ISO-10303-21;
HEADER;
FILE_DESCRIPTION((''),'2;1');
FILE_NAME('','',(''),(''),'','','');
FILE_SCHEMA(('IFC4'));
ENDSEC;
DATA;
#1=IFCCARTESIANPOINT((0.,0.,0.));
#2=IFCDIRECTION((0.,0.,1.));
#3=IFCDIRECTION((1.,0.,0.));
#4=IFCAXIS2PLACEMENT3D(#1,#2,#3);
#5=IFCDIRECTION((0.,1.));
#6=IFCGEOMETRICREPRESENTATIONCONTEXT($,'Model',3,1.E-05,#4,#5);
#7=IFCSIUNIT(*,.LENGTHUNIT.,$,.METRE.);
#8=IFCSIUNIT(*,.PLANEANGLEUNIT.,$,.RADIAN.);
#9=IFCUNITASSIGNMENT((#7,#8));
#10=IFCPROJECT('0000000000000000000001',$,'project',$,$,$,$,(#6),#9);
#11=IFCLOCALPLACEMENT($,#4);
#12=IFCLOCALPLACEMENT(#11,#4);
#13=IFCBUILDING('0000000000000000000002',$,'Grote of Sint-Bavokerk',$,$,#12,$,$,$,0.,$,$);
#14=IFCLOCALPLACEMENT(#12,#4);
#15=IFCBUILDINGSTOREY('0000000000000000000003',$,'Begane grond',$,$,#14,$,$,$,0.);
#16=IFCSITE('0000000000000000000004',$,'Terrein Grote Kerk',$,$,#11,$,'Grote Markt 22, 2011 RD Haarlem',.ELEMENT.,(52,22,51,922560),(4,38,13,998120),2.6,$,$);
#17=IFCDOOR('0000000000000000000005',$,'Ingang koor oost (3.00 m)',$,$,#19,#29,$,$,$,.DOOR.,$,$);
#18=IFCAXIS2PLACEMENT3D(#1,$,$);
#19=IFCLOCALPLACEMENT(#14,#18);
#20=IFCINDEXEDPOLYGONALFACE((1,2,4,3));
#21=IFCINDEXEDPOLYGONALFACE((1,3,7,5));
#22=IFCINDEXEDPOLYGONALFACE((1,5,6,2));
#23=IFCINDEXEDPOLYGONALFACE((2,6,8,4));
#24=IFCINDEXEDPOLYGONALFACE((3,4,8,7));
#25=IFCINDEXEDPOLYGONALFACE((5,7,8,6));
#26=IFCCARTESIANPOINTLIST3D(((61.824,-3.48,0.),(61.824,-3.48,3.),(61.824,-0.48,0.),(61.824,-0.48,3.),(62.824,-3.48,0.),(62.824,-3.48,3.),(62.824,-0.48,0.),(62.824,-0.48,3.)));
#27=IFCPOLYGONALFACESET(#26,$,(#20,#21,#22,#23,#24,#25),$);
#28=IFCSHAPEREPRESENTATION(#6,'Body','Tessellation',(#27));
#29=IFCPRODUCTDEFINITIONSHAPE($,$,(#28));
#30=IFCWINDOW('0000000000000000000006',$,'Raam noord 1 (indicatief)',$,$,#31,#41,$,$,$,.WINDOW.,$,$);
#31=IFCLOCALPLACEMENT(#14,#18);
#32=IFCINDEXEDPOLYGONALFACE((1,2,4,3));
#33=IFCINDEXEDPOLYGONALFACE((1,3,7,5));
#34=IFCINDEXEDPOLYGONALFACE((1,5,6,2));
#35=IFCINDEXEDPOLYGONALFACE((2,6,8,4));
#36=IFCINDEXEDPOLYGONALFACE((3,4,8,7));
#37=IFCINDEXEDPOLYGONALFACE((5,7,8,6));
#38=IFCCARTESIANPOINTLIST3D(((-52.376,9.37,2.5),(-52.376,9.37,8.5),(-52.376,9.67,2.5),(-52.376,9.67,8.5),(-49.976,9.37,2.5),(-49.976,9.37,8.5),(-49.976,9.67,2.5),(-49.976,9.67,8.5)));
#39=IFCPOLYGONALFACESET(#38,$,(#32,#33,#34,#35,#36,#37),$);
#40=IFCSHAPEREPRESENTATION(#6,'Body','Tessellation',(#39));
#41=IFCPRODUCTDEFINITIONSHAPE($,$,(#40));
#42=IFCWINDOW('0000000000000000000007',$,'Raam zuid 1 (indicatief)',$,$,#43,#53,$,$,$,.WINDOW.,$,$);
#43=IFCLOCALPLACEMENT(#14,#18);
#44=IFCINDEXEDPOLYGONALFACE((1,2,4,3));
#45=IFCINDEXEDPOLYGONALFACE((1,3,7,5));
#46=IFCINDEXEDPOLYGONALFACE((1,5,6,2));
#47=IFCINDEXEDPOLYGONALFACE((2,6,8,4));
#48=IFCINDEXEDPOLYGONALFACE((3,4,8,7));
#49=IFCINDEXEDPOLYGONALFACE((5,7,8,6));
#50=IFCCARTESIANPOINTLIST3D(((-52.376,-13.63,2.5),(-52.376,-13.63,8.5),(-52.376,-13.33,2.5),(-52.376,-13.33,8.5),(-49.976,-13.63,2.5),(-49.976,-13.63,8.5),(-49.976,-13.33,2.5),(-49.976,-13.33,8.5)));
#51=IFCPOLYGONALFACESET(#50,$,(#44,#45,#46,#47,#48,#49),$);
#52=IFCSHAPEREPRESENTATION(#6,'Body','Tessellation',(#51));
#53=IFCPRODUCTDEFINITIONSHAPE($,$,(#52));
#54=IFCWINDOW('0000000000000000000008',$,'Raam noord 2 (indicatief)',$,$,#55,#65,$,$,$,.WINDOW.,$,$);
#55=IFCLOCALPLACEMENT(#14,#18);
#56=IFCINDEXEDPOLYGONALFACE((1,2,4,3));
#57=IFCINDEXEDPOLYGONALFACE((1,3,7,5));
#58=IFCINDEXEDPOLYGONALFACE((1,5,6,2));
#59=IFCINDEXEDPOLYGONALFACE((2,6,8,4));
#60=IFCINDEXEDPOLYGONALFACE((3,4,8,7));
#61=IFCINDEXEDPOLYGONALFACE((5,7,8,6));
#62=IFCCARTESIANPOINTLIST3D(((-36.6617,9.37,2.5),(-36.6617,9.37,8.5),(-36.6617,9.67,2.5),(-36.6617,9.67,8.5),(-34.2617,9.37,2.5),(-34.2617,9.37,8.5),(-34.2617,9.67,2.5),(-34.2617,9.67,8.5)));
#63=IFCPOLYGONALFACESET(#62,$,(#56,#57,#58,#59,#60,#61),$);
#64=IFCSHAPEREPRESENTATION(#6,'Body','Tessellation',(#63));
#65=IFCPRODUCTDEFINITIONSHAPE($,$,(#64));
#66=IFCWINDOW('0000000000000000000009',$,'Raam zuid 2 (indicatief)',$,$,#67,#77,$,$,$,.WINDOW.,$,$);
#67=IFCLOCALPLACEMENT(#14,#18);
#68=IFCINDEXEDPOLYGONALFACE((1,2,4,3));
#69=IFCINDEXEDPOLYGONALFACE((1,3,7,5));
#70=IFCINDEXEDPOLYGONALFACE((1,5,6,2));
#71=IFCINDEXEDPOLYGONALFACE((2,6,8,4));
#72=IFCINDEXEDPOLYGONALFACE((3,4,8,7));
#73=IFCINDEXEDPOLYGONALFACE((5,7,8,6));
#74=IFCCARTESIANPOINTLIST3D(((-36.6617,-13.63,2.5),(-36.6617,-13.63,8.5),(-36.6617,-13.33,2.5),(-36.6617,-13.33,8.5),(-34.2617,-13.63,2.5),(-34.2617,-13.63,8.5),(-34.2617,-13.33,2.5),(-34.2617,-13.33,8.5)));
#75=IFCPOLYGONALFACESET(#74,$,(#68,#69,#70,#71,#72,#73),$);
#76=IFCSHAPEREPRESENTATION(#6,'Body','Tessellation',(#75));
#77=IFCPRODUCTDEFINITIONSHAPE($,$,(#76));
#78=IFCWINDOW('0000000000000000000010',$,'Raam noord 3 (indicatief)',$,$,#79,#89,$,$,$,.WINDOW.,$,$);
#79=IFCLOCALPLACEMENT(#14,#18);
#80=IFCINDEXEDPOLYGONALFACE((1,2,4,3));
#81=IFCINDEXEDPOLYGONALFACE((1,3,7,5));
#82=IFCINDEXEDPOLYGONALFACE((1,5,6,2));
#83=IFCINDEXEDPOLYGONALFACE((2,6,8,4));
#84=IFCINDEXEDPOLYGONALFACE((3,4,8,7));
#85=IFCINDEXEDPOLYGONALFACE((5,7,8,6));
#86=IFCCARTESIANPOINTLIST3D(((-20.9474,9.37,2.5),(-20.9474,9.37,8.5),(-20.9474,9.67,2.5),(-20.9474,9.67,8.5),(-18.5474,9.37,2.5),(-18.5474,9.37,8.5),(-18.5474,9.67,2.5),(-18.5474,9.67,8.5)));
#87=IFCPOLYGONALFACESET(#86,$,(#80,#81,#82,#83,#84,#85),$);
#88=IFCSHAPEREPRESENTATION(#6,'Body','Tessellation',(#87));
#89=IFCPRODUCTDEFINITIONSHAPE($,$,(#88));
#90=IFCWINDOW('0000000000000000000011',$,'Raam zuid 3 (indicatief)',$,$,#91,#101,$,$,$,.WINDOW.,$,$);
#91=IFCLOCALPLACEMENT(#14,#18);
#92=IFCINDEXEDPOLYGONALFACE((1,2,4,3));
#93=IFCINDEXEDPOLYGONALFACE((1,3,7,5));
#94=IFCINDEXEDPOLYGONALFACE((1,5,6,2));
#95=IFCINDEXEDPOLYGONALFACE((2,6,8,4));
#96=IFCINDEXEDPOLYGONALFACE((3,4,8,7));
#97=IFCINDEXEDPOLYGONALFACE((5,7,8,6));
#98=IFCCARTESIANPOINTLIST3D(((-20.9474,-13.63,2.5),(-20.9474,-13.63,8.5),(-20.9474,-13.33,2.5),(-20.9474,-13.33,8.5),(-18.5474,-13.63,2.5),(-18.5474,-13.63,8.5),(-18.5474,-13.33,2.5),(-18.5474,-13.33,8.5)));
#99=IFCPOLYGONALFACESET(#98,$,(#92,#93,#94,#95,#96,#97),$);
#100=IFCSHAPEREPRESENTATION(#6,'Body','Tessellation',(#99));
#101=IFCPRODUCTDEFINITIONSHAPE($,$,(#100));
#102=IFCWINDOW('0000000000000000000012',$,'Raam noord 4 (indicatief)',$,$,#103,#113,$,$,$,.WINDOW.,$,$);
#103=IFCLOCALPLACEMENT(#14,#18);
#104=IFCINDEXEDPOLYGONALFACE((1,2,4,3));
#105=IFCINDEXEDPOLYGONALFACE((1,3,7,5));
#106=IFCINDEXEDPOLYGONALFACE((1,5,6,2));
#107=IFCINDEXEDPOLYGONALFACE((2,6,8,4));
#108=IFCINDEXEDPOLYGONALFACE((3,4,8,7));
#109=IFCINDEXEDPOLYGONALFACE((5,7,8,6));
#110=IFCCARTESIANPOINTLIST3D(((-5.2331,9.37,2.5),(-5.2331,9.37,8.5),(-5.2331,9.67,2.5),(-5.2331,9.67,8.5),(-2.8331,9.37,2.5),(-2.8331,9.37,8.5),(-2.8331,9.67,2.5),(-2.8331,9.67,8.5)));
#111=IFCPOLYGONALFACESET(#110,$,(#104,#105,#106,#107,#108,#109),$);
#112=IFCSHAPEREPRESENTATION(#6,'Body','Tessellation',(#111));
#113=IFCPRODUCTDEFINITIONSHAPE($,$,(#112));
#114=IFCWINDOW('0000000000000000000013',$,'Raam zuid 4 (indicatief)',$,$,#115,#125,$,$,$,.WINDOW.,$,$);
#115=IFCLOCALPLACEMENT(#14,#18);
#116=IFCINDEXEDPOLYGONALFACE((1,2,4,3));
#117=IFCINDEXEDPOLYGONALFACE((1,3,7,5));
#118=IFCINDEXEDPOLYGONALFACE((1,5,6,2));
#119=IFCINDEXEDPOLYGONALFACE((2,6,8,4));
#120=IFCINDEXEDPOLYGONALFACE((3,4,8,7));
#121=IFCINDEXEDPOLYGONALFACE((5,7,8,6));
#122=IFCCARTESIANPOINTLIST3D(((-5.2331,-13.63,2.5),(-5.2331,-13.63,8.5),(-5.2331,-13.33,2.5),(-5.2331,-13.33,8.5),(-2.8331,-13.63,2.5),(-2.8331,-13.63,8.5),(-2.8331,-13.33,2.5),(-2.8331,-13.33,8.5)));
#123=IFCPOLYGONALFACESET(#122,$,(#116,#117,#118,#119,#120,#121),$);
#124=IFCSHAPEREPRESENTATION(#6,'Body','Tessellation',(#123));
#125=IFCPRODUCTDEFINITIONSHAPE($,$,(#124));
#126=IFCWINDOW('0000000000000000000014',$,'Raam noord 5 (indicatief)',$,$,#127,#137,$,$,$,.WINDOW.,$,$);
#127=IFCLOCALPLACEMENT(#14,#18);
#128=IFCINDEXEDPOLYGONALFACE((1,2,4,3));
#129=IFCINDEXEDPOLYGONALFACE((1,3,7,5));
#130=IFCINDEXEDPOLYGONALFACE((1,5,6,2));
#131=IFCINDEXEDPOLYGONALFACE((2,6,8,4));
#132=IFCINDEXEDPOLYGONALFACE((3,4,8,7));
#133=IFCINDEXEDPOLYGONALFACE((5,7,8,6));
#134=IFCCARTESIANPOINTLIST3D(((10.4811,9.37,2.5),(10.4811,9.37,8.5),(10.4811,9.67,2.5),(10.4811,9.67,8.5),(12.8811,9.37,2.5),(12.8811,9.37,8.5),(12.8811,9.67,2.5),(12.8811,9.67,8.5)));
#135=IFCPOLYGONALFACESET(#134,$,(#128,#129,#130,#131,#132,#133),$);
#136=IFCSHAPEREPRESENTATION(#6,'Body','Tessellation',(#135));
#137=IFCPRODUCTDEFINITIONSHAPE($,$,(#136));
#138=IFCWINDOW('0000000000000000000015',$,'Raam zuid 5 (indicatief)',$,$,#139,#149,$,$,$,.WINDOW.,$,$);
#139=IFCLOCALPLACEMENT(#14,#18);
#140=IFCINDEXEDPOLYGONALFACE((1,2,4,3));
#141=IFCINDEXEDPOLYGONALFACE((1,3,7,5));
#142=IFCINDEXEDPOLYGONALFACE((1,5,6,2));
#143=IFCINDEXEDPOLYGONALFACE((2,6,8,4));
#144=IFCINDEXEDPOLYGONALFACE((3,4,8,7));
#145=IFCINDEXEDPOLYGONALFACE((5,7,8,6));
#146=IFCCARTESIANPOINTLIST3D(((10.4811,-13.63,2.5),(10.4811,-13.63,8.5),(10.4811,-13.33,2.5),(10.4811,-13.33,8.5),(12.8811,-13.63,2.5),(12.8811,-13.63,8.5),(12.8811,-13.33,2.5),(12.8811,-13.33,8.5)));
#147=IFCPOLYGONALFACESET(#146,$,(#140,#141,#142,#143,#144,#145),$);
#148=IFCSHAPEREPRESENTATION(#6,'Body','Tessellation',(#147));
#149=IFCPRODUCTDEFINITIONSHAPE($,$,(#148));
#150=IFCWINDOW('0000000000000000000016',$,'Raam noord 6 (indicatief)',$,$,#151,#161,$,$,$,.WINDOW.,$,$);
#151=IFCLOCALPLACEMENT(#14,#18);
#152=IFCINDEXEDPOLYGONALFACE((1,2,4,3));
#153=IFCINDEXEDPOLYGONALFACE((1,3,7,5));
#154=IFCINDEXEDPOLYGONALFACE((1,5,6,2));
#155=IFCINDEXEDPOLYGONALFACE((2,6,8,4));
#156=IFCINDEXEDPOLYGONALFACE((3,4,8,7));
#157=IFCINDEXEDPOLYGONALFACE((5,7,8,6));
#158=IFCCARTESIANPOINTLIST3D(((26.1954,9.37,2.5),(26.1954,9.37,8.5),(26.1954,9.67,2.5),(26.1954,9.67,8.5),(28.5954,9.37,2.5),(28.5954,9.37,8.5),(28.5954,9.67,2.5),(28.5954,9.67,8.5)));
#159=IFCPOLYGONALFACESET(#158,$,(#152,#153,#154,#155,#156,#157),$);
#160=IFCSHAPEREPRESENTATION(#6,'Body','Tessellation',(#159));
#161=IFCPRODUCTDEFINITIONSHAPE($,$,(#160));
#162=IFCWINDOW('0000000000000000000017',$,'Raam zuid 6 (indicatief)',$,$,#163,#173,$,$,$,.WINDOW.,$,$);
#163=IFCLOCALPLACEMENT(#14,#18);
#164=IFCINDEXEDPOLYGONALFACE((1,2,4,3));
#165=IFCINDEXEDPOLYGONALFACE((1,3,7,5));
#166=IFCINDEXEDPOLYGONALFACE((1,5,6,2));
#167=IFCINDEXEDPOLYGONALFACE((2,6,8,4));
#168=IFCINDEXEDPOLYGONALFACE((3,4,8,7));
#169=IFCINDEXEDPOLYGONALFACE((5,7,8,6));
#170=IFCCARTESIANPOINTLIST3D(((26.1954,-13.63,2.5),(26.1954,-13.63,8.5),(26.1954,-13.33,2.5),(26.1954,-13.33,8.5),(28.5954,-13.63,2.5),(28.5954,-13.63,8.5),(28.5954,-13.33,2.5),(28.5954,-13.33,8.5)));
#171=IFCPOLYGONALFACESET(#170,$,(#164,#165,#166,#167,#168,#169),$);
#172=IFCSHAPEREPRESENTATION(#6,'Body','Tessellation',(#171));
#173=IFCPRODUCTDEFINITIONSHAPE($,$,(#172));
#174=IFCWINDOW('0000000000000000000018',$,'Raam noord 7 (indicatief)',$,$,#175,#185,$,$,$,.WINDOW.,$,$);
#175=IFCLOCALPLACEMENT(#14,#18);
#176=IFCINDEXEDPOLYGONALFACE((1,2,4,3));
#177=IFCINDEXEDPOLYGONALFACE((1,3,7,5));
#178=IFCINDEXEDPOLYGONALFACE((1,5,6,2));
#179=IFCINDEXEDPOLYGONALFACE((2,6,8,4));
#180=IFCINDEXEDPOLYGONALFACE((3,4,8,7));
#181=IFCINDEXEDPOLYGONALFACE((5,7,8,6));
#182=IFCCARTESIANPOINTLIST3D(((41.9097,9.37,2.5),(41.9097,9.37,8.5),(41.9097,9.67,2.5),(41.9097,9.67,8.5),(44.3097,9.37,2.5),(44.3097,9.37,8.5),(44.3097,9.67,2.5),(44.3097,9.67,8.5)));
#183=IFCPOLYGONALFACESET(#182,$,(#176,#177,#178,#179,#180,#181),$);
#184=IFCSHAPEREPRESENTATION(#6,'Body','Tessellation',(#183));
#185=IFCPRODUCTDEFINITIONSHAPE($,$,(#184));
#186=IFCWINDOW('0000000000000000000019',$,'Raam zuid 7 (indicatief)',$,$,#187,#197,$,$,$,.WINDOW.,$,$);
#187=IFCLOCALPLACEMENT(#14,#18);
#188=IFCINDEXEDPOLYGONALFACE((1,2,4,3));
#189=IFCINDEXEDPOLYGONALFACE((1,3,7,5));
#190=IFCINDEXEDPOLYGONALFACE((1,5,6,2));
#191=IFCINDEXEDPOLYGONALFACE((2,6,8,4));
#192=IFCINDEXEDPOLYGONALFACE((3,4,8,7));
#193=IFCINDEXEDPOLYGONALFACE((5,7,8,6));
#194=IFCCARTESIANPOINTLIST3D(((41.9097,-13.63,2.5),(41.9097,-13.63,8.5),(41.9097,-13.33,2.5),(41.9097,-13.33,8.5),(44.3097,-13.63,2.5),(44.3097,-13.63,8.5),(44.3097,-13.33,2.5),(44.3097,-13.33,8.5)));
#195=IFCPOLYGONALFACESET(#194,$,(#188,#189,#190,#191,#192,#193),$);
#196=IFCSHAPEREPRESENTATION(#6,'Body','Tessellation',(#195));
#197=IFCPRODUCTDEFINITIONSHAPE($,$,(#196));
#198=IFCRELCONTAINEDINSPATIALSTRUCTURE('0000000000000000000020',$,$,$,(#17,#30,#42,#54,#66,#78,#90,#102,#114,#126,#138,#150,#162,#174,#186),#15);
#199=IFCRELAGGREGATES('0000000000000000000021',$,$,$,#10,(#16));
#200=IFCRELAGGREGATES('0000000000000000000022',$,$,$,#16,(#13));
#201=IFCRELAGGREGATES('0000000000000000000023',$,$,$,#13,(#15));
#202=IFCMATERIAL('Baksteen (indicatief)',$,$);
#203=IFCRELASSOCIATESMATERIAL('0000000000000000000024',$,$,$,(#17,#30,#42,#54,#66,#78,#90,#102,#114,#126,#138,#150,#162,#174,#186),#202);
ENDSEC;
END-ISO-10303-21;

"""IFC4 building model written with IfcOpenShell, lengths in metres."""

from ifc_helpers import new_model, si_unit, direction, frame, origin_with_axes, place, context, project, spatial, indexed_curve, outline, extrude, material, element, save


model = new_model("IFC4")

# Units and contexts
model_context = context("Model", 3, precision=1e-05, world=origin_with_axes(), true_north=direction((0.0, 1.0)))
ifc_project = project(units=[si_unit("LENGTHUNIT", "METRE"), si_unit("PLANEANGLEUNIT", "RADIAN")], contexts=[model_context])

# Site, building, storey
site_placement = place(None, origin_with_axes())
site = spatial("IfcSite", under=ifc_project, at=site_placement, Name="Terrein Grote Kerk", LongName="Grote Markt 22, 2011 RD Haarlem", CompositionType="ELEMENT", RefLatitude=(52, 22, 51, 922560), RefLongitude=(4, 38, 13, 998120), RefElevation=2.6)
building_placement = place(site_placement, origin_with_axes())
building = spatial("IfcBuilding", under=site, at=building_placement, Name="Grote of Sint-Bavokerk", ElevationOfRefHeight=0.0)
storey_placement = place(building_placement, origin_with_axes())
storey = spatial("IfcBuildingStorey", under=building, at=storey_placement, Name="Begane grond", Elevation=0.0)

# Door
ifc_material = material(Name="Baksteen (indicatief)")
door_placement = place(storey_placement, origin_with_axes())
element("IfcDoor", 1, at=door_placement, inside=storey, material=ifc_material, Name="Ingang koor oost (3.00 m)", PredefinedType="DOOR", context=model_context, shape_type="SweptSolid", body=[
    extrude(outline(indexed_curve([(61.824, -3.48), (62.824, -3.48), (62.824, -0.48), (61.824, -0.48), (61.824, -3.48)])), origin_with_axes(), (0.0, 0.0, 1.0), 3.0),
])

# Windows
window_1_placement = place(storey_placement, origin_with_axes())
element("IfcWindow", 2, at=window_1_placement, inside=storey, material=ifc_material, Name="Raam noord 1 (indicatief)", PredefinedType="WINDOW", context=model_context, shape_type="SweptSolid", body=[
    extrude(outline(indexed_curve([(-52.376, 9.37), (-49.976, 9.37), (-49.976, 9.67), (-52.376, 9.67), (-52.376, 9.37)])), frame((0.0, 0.0, 2.5), z_axis=(0.0, 0.0, 1.0), x_axis=(1.0, 0.0, 0.0)), (0.0, 0.0, 1.0), 6.0),
])
window_2_placement = place(storey_placement, origin_with_axes())
element("IfcWindow", 3, at=window_2_placement, inside=storey, material=ifc_material, Name="Raam zuid 1 (indicatief)", PredefinedType="WINDOW", context=model_context, shape_type="SweptSolid", body=[
    extrude(outline(indexed_curve([(-52.376, -13.63), (-49.976, -13.63), (-49.976, -13.33), (-52.376, -13.33), (-52.376, -13.63)])), frame((0.0, 0.0, 2.5), z_axis=(0.0, 0.0, 1.0), x_axis=(1.0, 0.0, 0.0)), (0.0, 0.0, 1.0), 6.0),
])
window_3_placement = place(storey_placement, origin_with_axes())
element("IfcWindow", 4, at=window_3_placement, inside=storey, material=ifc_material, Name="Raam noord 2 (indicatief)", PredefinedType="WINDOW", context=model_context, shape_type="SweptSolid", body=[
    extrude(outline(indexed_curve([(-36.6617, 9.37), (-34.2617, 9.37), (-34.2617, 9.67), (-36.6617, 9.67), (-36.6617, 9.37)])), frame((0.0, 0.0, 2.5), z_axis=(0.0, 0.0, 1.0), x_axis=(1.0, 0.0, 0.0)), (0.0, 0.0, 1.0), 6.0),
])
window_4_placement = place(storey_placement, origin_with_axes())
element("IfcWindow", 5, at=window_4_placement, inside=storey, material=ifc_material, Name="Raam zuid 2 (indicatief)", PredefinedType="WINDOW", context=model_context, shape_type="SweptSolid", body=[
    extrude(outline(indexed_curve([(-36.6617, -13.63), (-34.2617, -13.63), (-34.2617, -13.33), (-36.6617, -13.33), (-36.6617, -13.63)])), frame((0.0, 0.0, 2.5), z_axis=(0.0, 0.0, 1.0), x_axis=(1.0, 0.0, 0.0)), (0.0, 0.0, 1.0), 6.0),
])
window_5_placement = place(storey_placement, origin_with_axes())
element("IfcWindow", 6, at=window_5_placement, inside=storey, material=ifc_material, Name="Raam noord 3 (indicatief)", PredefinedType="WINDOW", context=model_context, shape_type="SweptSolid", body=[
    extrude(outline(indexed_curve([(-20.9474, 9.37), (-18.5474, 9.37), (-18.5474, 9.67), (-20.9474, 9.67), (-20.9474, 9.37)])), frame((0.0, 0.0, 2.5), z_axis=(0.0, 0.0, 1.0), x_axis=(1.0, 0.0, 0.0)), (0.0, 0.0, 1.0), 6.0),
])
window_6_placement = place(storey_placement, origin_with_axes())
element("IfcWindow", 7, at=window_6_placement, inside=storey, material=ifc_material, Name="Raam zuid 3 (indicatief)", PredefinedType="WINDOW", context=model_context, shape_type="SweptSolid", body=[
    extrude(outline(indexed_curve([(-20.9474, -13.63), (-18.5474, -13.63), (-18.5474, -13.33), (-20.9474, -13.33), (-20.9474, -13.63)])), frame((0.0, 0.0, 2.5), z_axis=(0.0, 0.0, 1.0), x_axis=(1.0, 0.0, 0.0)), (0.0, 0.0, 1.0), 6.0),
])
window_7_placement = place(storey_placement, origin_with_axes())
element("IfcWindow", 8, at=window_7_placement, inside=storey, material=ifc_material, Name="Raam noord 4 (indicatief)", PredefinedType="WINDOW", context=model_context, shape_type="SweptSolid", body=[
    extrude(outline(indexed_curve([(-5.2331, 9.37), (-2.8331, 9.37), (-2.8331, 9.67), (-5.2331, 9.67), (-5.2331, 9.37)])), frame((0.0, 0.0, 2.5), z_axis=(0.0, 0.0, 1.0), x_axis=(1.0, 0.0, 0.0)), (0.0, 0.0, 1.0), 6.0),
])
window_8_placement = place(storey_placement, origin_with_axes())
element("IfcWindow", 9, at=window_8_placement, inside=storey, material=ifc_material, Name="Raam zuid 4 (indicatief)", PredefinedType="WINDOW", context=model_context, shape_type="SweptSolid", body=[
    extrude(outline(indexed_curve([(-5.2331, -13.63), (-2.8331, -13.63), (-2.8331, -13.33), (-5.2331, -13.33), (-5.2331, -13.63)])), frame((0.0, 0.0, 2.5), z_axis=(0.0, 0.0, 1.0), x_axis=(1.0, 0.0, 0.0)), (0.0, 0.0, 1.0), 6.0),
])
window_9_placement = place(storey_placement, origin_with_axes())
element("IfcWindow", 10, at=window_9_placement, inside=storey, material=ifc_material, Name="Raam noord 5 (indicatief)", PredefinedType="WINDOW", context=model_context, shape_type="SweptSolid", body=[
    extrude(outline(indexed_curve([(10.4811, 9.37), (12.8811, 9.37), (12.8811, 9.67), (10.4811, 9.67), (10.4811, 9.37)])), frame((0.0, 0.0, 2.5), z_axis=(0.0, 0.0, 1.0), x_axis=(1.0, 0.0, 0.0)), (0.0, 0.0, 1.0), 6.0),
])
window_10_placement = place(storey_placement, origin_with_axes())
element("IfcWindow", 11, at=window_10_placement, inside=storey, material=ifc_material, Name="Raam zuid 5 (indicatief)", PredefinedType="WINDOW", context=model_context, shape_type="SweptSolid", body=[
    extrude(outline(indexed_curve([(10.4811, -13.63), (12.8811, -13.63), (12.8811, -13.33), (10.4811, -13.33), (10.4811, -13.63)])), frame((0.0, 0.0, 2.5), z_axis=(0.0, 0.0, 1.0), x_axis=(1.0, 0.0, 0.0)), (0.0, 0.0, 1.0), 6.0),
])
window_11_placement = place(storey_placement, origin_with_axes())
element("IfcWindow", 12, at=window_11_placement, inside=storey, material=ifc_material, Name="Raam noord 6 (indicatief)", PredefinedType="WINDOW", context=model_context, shape_type="SweptSolid", body=[
    extrude(outline(indexed_curve([(26.1954, 9.37), (28.5954, 9.37), (28.5954, 9.67), (26.1954, 9.67), (26.1954, 9.37)])), frame((0.0, 0.0, 2.5), z_axis=(0.0, 0.0, 1.0), x_axis=(1.0, 0.0, 0.0)), (0.0, 0.0, 1.0), 6.0),
])
window_12_placement = place(storey_placement, origin_with_axes())
element("IfcWindow", 13, at=window_12_placement, inside=storey, material=ifc_material, Name="Raam zuid 6 (indicatief)", PredefinedType="WINDOW", context=model_context, shape_type="SweptSolid", body=[
    extrude(outline(indexed_curve([(26.1954, -13.63), (28.5954, -13.63), (28.5954, -13.33), (26.1954, -13.33), (26.1954, -13.63)])), frame((0.0, 0.0, 2.5), z_axis=(0.0, 0.0, 1.0), x_axis=(1.0, 0.0, 0.0)), (0.0, 0.0, 1.0), 6.0),
])
window_13_placement = place(storey_placement, origin_with_axes())
element("IfcWindow", 14, at=window_13_placement, inside=storey, material=ifc_material, Name="Raam noord 7 (indicatief)", PredefinedType="WINDOW", context=model_context, shape_type="SweptSolid", body=[
    extrude(outline(indexed_curve([(41.9097, 9.37), (44.3097, 9.37), (44.3097, 9.67), (41.9097, 9.67), (41.9097, 9.37)])), frame((0.0, 0.0, 2.5), z_axis=(0.0, 0.0, 1.0), x_axis=(1.0, 0.0, 0.0)), (0.0, 0.0, 1.0), 6.0),
])
window_14_placement = place(storey_placement, origin_with_axes())
element("IfcWindow", 15, at=window_14_placement, inside=storey, material=ifc_material, Name="Raam zuid 7 (indicatief)", PredefinedType="WINDOW", context=model_context, shape_type="SweptSolid", body=[
    extrude(outline(indexed_curve([(41.9097, -13.63), (44.3097, -13.63), (44.3097, -13.33), (41.9097, -13.33), (41.9097, -13.63)])), frame((0.0, 0.0, 2.5), z_axis=(0.0, 0.0, 1.0), x_axis=(1.0, 0.0, 0.0)), (0.0, 0.0, 1.0), 6.0),
])

save(model, "model.ifc")
